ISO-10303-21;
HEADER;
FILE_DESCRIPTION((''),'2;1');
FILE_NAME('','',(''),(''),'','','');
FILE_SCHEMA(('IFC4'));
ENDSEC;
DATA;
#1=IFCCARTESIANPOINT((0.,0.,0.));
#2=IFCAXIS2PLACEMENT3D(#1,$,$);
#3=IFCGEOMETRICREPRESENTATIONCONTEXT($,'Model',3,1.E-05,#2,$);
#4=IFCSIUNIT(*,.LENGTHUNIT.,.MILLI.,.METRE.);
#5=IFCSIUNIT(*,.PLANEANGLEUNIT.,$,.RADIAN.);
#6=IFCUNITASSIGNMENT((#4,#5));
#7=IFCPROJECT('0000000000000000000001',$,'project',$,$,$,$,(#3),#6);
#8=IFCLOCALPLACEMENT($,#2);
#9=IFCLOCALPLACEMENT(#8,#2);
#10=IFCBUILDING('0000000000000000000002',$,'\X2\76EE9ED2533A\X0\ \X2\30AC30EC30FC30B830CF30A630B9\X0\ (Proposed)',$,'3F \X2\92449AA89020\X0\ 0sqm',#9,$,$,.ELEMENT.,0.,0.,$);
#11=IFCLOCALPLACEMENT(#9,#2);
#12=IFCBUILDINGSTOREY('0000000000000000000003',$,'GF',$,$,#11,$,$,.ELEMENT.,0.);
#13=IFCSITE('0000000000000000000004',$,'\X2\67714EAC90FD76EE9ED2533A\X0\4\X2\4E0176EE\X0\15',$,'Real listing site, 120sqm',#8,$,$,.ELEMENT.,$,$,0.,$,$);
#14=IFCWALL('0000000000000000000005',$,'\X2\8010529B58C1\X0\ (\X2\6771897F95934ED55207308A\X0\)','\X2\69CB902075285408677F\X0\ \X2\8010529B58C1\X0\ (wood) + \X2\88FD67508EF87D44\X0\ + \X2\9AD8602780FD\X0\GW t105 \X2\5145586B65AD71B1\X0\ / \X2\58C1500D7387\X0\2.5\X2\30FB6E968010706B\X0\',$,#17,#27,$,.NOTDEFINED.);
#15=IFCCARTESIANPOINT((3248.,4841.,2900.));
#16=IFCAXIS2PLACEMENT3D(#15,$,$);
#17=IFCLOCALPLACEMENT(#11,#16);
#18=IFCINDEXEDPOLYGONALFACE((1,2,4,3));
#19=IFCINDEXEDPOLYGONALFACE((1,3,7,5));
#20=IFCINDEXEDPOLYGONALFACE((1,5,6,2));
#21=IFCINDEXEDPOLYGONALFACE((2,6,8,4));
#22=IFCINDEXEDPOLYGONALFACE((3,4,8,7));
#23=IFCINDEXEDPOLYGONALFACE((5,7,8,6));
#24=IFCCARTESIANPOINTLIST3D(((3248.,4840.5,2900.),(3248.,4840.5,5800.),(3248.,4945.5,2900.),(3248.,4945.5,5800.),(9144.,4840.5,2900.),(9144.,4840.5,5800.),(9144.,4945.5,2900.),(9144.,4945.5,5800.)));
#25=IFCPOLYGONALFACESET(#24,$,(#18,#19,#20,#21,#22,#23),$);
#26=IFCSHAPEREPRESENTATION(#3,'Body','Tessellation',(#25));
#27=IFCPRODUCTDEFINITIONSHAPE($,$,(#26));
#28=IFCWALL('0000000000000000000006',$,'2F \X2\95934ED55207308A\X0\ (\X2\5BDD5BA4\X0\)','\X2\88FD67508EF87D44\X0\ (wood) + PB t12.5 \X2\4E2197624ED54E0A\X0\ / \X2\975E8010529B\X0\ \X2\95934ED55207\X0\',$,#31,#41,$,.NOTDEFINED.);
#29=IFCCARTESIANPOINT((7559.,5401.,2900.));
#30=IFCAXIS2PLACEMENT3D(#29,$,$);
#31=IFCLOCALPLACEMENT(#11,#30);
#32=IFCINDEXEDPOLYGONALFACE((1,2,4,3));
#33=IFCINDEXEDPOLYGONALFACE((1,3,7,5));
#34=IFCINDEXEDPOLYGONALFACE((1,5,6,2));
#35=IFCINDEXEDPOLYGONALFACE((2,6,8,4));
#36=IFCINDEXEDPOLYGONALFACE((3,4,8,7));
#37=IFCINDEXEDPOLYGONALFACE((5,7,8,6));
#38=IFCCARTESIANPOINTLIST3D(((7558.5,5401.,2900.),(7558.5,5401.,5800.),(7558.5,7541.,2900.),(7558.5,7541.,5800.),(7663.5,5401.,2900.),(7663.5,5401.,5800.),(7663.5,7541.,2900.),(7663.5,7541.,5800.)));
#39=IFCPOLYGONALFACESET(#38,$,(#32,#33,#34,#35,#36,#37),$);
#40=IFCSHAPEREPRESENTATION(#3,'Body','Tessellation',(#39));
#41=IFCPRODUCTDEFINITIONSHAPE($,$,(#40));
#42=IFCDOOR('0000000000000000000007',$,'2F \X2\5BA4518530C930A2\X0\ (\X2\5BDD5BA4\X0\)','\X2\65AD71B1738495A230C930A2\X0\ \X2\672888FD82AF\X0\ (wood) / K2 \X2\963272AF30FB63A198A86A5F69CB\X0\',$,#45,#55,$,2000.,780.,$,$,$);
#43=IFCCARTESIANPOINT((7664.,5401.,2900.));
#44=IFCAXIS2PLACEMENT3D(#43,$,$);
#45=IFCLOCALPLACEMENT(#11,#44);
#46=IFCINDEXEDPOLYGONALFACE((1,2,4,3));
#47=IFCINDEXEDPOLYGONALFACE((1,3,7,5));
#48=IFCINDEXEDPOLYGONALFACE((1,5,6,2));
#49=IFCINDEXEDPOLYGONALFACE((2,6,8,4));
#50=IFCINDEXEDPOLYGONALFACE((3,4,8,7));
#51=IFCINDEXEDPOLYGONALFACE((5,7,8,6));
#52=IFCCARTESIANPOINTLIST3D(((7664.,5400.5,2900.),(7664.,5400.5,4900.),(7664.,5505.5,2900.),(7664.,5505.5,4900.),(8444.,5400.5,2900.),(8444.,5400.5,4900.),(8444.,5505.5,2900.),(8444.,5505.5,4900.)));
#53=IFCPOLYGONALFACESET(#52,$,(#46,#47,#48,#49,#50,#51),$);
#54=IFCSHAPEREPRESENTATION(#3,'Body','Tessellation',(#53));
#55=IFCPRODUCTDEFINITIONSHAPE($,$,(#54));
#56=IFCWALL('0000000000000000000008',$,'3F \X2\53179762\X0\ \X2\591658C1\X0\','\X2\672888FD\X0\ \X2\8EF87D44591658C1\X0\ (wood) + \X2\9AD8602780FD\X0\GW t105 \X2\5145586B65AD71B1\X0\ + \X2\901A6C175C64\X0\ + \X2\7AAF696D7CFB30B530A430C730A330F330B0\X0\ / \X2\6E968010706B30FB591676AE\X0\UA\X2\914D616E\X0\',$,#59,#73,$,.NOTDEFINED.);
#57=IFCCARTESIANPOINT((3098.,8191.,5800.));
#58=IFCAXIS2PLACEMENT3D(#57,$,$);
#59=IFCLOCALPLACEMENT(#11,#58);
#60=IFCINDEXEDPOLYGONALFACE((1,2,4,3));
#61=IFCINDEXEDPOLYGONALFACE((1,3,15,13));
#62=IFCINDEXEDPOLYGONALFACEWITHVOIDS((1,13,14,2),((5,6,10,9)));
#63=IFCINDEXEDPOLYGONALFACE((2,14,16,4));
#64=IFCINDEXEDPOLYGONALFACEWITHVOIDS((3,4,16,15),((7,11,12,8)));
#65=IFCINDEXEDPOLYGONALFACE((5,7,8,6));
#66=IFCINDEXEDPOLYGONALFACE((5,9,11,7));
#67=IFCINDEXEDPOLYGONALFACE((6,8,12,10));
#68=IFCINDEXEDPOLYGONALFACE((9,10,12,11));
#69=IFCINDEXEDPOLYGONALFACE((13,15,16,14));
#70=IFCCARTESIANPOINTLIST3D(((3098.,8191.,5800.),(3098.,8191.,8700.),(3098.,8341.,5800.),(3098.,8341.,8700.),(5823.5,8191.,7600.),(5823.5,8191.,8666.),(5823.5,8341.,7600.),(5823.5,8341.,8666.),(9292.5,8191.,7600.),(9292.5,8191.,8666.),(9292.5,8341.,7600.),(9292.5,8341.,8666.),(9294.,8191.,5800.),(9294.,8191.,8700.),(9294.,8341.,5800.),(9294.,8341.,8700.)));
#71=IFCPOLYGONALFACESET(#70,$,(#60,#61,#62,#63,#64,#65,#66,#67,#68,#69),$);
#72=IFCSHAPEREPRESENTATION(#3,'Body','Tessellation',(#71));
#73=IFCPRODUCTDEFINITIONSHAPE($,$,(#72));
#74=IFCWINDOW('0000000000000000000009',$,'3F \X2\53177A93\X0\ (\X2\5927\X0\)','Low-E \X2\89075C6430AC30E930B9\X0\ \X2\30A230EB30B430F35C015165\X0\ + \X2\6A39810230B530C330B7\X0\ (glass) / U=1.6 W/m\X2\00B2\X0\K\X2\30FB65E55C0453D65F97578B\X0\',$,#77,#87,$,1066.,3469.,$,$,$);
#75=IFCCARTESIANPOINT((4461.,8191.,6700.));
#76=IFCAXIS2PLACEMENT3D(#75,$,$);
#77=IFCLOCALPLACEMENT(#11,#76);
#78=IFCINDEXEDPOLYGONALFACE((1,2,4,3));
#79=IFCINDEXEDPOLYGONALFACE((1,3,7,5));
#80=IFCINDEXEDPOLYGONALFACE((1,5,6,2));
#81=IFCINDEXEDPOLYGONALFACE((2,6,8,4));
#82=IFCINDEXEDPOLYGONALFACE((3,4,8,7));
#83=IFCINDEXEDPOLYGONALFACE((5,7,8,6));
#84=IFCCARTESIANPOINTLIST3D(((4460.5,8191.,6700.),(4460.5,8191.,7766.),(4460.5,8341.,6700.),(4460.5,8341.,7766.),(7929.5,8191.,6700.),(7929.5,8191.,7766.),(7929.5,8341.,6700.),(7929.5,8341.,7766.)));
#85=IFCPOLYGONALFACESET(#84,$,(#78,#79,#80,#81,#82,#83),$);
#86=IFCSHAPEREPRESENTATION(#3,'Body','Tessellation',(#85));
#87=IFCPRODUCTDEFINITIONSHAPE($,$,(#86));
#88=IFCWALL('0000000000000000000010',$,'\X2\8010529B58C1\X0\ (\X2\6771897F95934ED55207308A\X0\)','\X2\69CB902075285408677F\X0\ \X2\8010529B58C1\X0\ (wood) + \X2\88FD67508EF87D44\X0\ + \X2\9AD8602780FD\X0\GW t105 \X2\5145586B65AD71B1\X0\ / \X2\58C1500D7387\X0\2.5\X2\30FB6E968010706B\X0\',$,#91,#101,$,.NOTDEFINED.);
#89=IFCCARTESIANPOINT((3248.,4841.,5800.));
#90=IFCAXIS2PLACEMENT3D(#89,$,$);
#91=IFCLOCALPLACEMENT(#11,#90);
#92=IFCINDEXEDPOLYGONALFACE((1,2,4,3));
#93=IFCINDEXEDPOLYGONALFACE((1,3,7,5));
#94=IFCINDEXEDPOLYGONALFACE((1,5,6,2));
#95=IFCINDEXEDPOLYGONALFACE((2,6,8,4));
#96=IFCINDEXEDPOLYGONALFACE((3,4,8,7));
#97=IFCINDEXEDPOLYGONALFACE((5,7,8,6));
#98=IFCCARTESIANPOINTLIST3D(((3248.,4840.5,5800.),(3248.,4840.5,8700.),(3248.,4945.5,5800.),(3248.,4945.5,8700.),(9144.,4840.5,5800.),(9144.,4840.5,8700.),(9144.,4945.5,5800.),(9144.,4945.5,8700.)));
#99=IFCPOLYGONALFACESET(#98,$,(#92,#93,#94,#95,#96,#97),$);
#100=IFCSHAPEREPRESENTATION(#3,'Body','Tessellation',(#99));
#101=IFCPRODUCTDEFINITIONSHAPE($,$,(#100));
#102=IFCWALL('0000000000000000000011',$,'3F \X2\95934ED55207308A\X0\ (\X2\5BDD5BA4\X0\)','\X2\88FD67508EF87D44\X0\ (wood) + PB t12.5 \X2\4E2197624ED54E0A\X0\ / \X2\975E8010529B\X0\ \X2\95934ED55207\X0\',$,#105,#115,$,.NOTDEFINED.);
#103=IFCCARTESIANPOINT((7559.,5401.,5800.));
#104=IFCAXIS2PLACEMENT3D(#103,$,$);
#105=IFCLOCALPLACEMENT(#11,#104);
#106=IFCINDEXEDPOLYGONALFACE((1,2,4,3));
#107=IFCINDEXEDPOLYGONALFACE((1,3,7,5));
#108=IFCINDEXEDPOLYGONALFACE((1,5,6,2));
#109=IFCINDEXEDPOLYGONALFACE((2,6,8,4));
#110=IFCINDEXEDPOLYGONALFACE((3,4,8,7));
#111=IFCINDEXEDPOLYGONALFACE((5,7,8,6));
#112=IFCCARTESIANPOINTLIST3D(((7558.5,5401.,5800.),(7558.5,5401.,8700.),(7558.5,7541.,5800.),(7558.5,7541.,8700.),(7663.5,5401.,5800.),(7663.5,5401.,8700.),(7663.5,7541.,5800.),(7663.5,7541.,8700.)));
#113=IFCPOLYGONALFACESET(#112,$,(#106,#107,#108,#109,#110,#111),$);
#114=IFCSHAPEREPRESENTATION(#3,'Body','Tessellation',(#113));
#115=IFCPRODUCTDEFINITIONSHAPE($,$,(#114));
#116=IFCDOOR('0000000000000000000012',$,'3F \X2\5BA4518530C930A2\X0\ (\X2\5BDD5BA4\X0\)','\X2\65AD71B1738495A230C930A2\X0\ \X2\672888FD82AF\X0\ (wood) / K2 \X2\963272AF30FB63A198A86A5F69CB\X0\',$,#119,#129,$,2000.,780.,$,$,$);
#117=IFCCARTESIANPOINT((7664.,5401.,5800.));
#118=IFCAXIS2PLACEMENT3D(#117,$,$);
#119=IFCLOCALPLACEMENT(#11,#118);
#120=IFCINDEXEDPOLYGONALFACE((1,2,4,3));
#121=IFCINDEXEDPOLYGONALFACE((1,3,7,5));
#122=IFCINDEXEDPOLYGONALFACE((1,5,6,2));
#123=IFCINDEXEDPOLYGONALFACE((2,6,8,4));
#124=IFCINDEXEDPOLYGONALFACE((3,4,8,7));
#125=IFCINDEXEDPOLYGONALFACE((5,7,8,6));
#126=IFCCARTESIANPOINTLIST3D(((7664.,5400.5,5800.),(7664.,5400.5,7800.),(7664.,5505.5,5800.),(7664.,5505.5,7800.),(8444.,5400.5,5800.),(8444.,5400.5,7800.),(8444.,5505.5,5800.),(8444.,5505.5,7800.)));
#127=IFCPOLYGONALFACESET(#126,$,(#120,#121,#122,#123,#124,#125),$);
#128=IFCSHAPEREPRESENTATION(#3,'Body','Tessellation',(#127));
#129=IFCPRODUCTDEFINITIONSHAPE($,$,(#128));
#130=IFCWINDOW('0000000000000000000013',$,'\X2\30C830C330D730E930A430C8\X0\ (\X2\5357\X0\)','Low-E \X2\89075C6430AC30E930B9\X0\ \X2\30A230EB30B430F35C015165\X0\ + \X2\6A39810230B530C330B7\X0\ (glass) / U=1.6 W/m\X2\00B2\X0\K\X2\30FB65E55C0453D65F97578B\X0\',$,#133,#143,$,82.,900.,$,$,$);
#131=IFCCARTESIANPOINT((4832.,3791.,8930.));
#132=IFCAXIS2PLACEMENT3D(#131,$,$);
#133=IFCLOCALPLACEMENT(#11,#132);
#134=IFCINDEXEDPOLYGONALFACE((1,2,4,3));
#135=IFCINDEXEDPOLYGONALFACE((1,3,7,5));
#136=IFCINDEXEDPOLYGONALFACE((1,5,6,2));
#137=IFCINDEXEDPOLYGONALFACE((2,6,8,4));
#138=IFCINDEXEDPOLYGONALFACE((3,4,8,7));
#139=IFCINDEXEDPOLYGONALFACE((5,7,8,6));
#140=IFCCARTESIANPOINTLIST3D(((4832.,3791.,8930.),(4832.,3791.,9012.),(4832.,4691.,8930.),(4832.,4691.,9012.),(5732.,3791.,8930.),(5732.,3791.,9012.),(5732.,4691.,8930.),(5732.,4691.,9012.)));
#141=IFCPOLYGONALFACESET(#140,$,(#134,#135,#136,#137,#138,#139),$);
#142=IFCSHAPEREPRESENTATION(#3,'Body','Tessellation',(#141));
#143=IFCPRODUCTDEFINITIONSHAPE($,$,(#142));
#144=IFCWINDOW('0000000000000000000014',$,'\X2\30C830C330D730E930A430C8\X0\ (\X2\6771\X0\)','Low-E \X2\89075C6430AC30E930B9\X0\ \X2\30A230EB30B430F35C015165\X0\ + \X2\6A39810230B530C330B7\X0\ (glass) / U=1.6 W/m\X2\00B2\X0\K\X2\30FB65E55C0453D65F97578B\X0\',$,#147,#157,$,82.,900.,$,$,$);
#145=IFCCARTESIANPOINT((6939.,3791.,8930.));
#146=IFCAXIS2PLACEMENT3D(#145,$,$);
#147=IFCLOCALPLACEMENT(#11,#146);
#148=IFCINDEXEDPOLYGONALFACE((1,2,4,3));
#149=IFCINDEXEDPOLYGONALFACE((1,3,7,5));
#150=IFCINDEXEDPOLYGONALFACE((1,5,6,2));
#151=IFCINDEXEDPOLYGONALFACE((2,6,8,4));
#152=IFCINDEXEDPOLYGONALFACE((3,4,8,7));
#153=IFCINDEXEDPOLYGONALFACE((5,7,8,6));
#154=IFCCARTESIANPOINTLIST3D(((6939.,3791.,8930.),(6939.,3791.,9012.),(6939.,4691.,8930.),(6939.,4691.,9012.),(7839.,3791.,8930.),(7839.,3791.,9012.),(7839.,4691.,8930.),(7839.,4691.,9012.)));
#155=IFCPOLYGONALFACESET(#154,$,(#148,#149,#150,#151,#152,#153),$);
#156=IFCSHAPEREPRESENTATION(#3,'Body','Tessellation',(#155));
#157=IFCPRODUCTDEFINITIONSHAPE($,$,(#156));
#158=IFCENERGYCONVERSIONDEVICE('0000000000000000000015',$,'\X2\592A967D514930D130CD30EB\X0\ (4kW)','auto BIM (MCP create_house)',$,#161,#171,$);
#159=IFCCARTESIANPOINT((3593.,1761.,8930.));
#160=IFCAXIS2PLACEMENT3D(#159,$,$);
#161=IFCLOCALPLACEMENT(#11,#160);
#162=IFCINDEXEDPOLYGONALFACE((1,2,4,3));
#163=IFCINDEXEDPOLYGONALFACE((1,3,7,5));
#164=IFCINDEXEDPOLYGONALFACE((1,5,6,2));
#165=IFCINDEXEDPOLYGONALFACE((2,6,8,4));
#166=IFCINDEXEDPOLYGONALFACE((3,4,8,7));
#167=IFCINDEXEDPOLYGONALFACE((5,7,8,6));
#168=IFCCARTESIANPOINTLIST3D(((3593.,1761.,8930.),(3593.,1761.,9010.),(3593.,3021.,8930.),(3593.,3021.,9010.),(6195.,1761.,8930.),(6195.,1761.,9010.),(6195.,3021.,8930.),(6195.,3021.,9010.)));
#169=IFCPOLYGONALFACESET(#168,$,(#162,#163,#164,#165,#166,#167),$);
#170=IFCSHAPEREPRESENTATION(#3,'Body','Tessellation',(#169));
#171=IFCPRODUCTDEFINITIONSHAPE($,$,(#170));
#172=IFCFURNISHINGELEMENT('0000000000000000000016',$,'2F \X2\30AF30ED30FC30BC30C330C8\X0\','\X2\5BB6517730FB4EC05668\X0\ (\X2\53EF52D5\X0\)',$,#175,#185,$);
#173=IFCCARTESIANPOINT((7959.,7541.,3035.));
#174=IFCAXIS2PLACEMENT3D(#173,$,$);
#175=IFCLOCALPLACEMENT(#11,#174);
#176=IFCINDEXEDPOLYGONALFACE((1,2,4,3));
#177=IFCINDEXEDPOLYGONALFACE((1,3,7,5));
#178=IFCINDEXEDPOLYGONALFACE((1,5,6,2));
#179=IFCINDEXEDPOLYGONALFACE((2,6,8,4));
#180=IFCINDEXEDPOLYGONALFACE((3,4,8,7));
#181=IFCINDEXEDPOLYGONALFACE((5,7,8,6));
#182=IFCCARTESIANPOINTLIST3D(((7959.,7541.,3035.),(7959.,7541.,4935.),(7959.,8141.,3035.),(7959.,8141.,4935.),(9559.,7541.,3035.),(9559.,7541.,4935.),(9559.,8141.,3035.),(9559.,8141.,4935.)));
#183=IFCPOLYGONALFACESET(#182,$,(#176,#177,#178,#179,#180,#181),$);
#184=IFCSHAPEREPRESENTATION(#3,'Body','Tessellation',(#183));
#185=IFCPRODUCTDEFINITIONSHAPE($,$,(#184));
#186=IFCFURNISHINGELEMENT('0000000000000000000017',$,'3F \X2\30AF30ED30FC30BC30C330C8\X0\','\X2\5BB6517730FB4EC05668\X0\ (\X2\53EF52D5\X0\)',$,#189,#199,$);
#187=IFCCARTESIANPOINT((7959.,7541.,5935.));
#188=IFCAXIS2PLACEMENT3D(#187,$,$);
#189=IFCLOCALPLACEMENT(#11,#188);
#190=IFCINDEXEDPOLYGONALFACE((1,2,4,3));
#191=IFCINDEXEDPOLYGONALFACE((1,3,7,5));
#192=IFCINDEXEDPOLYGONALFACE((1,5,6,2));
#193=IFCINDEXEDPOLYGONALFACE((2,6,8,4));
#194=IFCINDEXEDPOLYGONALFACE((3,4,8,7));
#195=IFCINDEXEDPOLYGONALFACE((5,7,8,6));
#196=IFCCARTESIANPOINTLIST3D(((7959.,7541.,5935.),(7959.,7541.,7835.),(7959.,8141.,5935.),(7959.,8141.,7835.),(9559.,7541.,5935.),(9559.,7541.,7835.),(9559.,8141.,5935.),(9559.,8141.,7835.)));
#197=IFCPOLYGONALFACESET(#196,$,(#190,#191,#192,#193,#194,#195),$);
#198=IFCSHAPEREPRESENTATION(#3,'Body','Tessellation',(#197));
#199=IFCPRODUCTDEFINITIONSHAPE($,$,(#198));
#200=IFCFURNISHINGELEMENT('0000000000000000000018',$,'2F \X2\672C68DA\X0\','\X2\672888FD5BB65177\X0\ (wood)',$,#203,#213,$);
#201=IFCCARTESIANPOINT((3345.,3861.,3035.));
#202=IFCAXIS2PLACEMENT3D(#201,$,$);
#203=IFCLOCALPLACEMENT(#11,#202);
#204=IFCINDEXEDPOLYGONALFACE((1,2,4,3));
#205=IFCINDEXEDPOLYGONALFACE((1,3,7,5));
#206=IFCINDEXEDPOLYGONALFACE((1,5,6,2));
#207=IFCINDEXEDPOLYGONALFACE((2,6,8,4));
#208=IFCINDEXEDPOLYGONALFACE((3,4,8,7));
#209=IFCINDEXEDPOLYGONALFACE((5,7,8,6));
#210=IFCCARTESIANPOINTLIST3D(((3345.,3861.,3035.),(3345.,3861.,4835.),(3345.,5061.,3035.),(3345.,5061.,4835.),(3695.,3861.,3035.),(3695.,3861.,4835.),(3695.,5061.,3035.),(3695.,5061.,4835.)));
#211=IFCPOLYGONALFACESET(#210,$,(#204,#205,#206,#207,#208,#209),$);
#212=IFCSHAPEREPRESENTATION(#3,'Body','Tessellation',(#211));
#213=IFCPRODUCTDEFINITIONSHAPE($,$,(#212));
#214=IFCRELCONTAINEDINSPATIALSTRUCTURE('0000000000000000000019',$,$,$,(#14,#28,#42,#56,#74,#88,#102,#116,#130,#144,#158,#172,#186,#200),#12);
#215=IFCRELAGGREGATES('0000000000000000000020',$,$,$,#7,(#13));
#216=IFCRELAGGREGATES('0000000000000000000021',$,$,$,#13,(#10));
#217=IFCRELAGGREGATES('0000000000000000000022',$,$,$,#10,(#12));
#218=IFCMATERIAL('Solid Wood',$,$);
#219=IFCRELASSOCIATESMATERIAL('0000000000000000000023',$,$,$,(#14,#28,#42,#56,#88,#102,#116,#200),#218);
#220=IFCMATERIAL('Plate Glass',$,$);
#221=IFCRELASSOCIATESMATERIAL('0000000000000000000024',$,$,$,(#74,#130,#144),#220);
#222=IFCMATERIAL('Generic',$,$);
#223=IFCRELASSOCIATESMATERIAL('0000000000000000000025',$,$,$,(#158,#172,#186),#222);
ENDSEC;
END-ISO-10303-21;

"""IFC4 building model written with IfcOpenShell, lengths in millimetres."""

from ifc_helpers import new_model, si_unit, frame, frame_2d, origin, place, context, project, spatial, rectangle, extrude, material, element, fill, save


model = new_model("IFC4")

# Units and contexts
model_context = context("Model", 3, precision=1e-05, world=origin())
ifc_project = project(units=[si_unit("LENGTHUNIT", "METRE", prefix="MILLI"), si_unit("PLANEANGLEUNIT", "RADIAN")], contexts=[model_context])

# Site, building, storey
site_placement = place(None, origin())
site = spatial("IfcSite", under=ifc_project, at=site_placement, Name="東京都目黒区4丁目15", ObjectType="Real listing site, 120sqm", CompositionType="ELEMENT", RefElevation=0.0)
building_placement = place(site_placement, origin())
building = spatial("IfcBuilding", under=site, at=building_placement, Name="目黒区 ガレージハウス (Proposed)", ObjectType="3F 鉄骨造 0sqm", CompositionType="ELEMENT", ElevationOfRefHeight=0.0, ElevationOfTerrain=0.0)
storey_placement = place(building_placement, origin())
storey = spatial("IfcBuildingStorey", under=building, at=storey_placement, Name="GF", CompositionType="ELEMENT", Elevation=0.0)

# Walls
ifc_material_1 = material(Name="Solid Wood")
wall_1_placement = place(storey_placement, frame((3248.0, 4841.0, 2900.0)))
element("IfcWall", 1, at=wall_1_placement, inside=storey, material=ifc_material_1, Name="耐力壁 (東西間仕切り)", Description="構造用合板 耐力壁 (wood) + 製材軸組 + 高性能GW t105 充填断熱 / 壁倍率2.5・準耐火", PredefinedType="NOTDEFINED", context=model_context, shape_type="SweptSolid", body=[
    extrude(rectangle(XDim=5896.0, YDim=105.0, at=frame_2d((2948.0, 52.0))), frame((3248.0, 4841.0, 2900.0)), (0.0, 0.0, 1.0), 2900.0),
])
wall_2_placement = place(storey_placement, frame((7559.0, 5401.0, 2900.0)))
element("IfcWall", 2, at=wall_2_placement, inside=storey, material=ifc_material_1, Name="2F 間仕切り (寝室)", Description="製材軸組 (wood) + PB t12.5 両面仕上 / 非耐力 間仕切", PredefinedType="NOTDEFINED", context=model_context, shape_type="SweptSolid", body=[
    extrude(rectangle(XDim=105.0, YDim=2140.0, at=frame_2d((52.0, 1070.0))), frame((7559.0, 5401.0, 2900.0)), (0.0, 0.0, 1.0), 2900.0),
])

# Door
door_1_placement = place(storey_placement, frame((7664.0, 5401.0, 2900.0)))
element("IfcDoor", 3, at=door_1_placement, inside=storey, material=ifc_material_1, Name="2F 室内ドア (寝室)", Description="断熱玄関ドア 木製芯 (wood) / K2 防犯・採風機構", OverallHeight=2000.0, OverallWidth=780.0, context=model_context, shape_type="SweptSolid", body=[
    extrude(rectangle(XDim=780.0, YDim=105.0, at=frame_2d((390.0, 52.0))), frame((7664.0, 5401.0, 2900.0)), (0.0, 0.0, 1.0), 2000.0),
])

# Wall, opening, window
wall_3_placement = place(storey_placement, frame((3098.0, 8191.0, 5800.0)))
wall_3 = element("IfcWall", 4, at=wall_3_placement, inside=storey, material=ifc_material_1, Name="3F 北面 外壁", Description="木製 軸組外壁 (wood) + 高性能GW t105 充填断熱 + 通気層 + 窯業系サイディング / 準耐火・外皮UA配慮", PredefinedType="NOTDEFINED", context=model_context, shape_type="SweptSolid", body=[
    extrude(rectangle(XDim=6196.0, YDim=150.0, at=frame_2d((3098.0, 75.0))), frame((3098.0, 8191.0, 5800.0)), (0.0, 0.0, 1.0), 2900.0),
])
opening_placement = place(storey_placement, frame((4461.0, 8191.0, 6700.0)))
opening = element("IfcOpeningElement", 5, at=opening_placement, cuts=wall_3, PredefinedType="NOTDEFINED", context=model_context, shape_type="SweptSolid", body=[
    extrude(rectangle(XDim=3469.0, YDim=150.0, at=frame_2d((1734.0, 75.0))), frame((4461.0, 8191.0, 6700.0)), (0.0, 0.0, 1.0), 1066.0),
])
ifc_material_2 = material(Name="Plate Glass")
window_1_placement = place(storey_placement, frame((4461.0, 8191.0, 6700.0)))
window_1 = element("IfcWindow", 6, at=window_1_placement, inside=storey, material=ifc_material_2, Name="3F 北窓 (大)", Description="Low-E 複層ガラス アルゴン封入 + 樹脂サッシ (glass) / U=1.6 W/m²K・日射取得型", OverallHeight=1066.0, OverallWidth=3469.0, context=model_context, shape_type="SweptSolid", body=[
    extrude(rectangle(XDim=3469.0, YDim=150.0, at=frame_2d((1734.0, 75.0))), frame((4461.0, 8191.0, 6700.0)), (0.0, 0.0, 1.0), 1066.0),
])
fill(opening, window_1)

# Walls
wall_4_placement = place(storey_placement, frame((3248.0, 4841.0, 5800.0)))
element("IfcWall", 7, at=wall_4_placement, inside=storey, material=ifc_material_1, Name="耐力壁 (東西間仕切り)", Description="構造用合板 耐力壁 (wood) + 製材軸組 + 高性能GW t105 充填断熱 / 壁倍率2.5・準耐火", PredefinedType="NOTDEFINED", context=model_context, shape_type="SweptSolid", body=[
    extrude(rectangle(XDim=5896.0, YDim=105.0, at=frame_2d((2948.0, 52.0))), frame((3248.0, 4841.0, 5800.0)), (0.0, 0.0, 1.0), 2900.0),
])
wall_5_placement = place(storey_placement, frame((7559.0, 5401.0, 5800.0)))
element("IfcWall", 8, at=wall_5_placement, inside=storey, material=ifc_material_1, Name="3F 間仕切り (寝室)", Description="製材軸組 (wood) + PB t12.5 両面仕上 / 非耐力 間仕切", PredefinedType="NOTDEFINED", context=model_context, shape_type="SweptSolid", body=[
    extrude(rectangle(XDim=105.0, YDim=2140.0, at=frame_2d((52.0, 1070.0))), frame((7559.0, 5401.0, 5800.0)), (0.0, 0.0, 1.0), 2900.0),
])

# Door
door_2_placement = place(storey_placement, frame((7664.0, 5401.0, 5800.0)))
element("IfcDoor", 9, at=door_2_placement, inside=storey, material=ifc_material_1, Name="3F 室内ドア (寝室)", Description="断熱玄関ドア 木製芯 (wood) / K2 防犯・採風機構", OverallHeight=2000.0, OverallWidth=780.0, context=model_context, shape_type="SweptSolid", body=[
    extrude(rectangle(XDim=780.0, YDim=105.0, at=frame_2d((390.0, 52.0))), frame((7664.0, 5401.0, 5800.0)), (0.0, 0.0, 1.0), 2000.0),
])

# Windows
window_2_placement = place(storey_placement, frame((4832.0, 3791.0, 8930.0)))
element("IfcWindow", 10, at=window_2_placement, inside=storey, material=ifc_material_2, Name="トップライト (南)", Description="Low-E 複層ガラス アルゴン封入 + 樹脂サッシ (glass) / U=1.6 W/m²K・日射取得型", OverallHeight=82.0, OverallWidth=900.0, context=model_context, shape_type="SweptSolid", body=[
    extrude(rectangle(XDim=900.0, YDim=900.0, at=frame_2d((450.0, 450.0))), frame((4832.0, 3791.0, 8930.0)), (0.0, 0.0, 1.0), 82.0),
])
window_3_placement = place(storey_placement, frame((6939.0, 3791.0, 8930.0)))
element("IfcWindow", 11, at=window_3_placement, inside=storey, material=ifc_material_2, Name="トップライト (東)", Description="Low-E 複層ガラス アルゴン封入 + 樹脂サッシ (glass) / U=1.6 W/m²K・日射取得型", OverallHeight=82.0, OverallWidth=900.0, context=model_context, shape_type="SweptSolid", body=[
    extrude(rectangle(XDim=900.0, YDim=900.0, at=frame_2d((450.0, 450.0))), frame((6939.0, 3791.0, 8930.0)), (0.0, 0.0, 1.0), 82.0),
])

# Energy conversion device
ifc_material_3 = material(Name="Generic")
energy_conversion_device_placement = place(storey_placement, frame((3593.0, 1761.0, 8930.0)))
element("IfcEnergyConversionDevice", 12, at=energy_conversion_device_placement, inside=storey, material=ifc_material_3, Name="太陽光パネル (4kW)", Description="auto BIM (MCP create_house)", context=model_context, shape_type="SweptSolid", body=[
    extrude(rectangle(XDim=2602.0, YDim=1260.0, at=frame_2d((1301.0, 630.0))), frame((3593.0, 1761.0, 8930.0)), (0.0, 0.0, 1.0), 80.0),
])

# Furnishing elements
furnishing_1_placement = place(storey_placement, frame((7959.0, 7541.0, 3035.0)))
element("IfcFurnishingElement", 13, at=furnishing_1_placement, inside=storey, material=ifc_material_3, Name="2F クローゼット", Description="家具・什器 (可動)", context=model_context, shape_type="SweptSolid", body=[
    extrude(rectangle(XDim=1600.0, YDim=600.0, at=frame_2d((800.0, 300.0))), frame((7959.0, 7541.0, 3035.0)), (0.0, 0.0, 1.0), 1900.0),
])
furnishing_2_placement = place(storey_placement, frame((7959.0, 7541.0, 5935.0)))
element("IfcFurnishingElement", 14, at=furnishing_2_placement, inside=storey, material=ifc_material_3, Name="3F クローゼット", Description="家具・什器 (可動)", context=model_context, shape_type="SweptSolid", body=[
    extrude(rectangle(XDim=1600.0, YDim=600.0, at=frame_2d((800.0, 300.0))), frame((7959.0, 7541.0, 5935.0)), (0.0, 0.0, 1.0), 1900.0),
])
furnishing_3_placement = place(storey_placement, frame((3345.0, 3861.0, 3035.0)))
element("IfcFurnishingElement", 15, at=furnishing_3_placement, inside=storey, material=ifc_material_1, Name="2F 本棚", Description="木製家具 (wood)", context=model_context, shape_type="SweptSolid", body=[
    extrude(rectangle(XDim=350.0, YDim=1200.0, at=frame_2d((175.0, 600.0))), frame((3345.0, 3861.0, 3035.0)), (0.0, 0.0, 1.0), 1800.0),
])

save(model, "model.ifc")
